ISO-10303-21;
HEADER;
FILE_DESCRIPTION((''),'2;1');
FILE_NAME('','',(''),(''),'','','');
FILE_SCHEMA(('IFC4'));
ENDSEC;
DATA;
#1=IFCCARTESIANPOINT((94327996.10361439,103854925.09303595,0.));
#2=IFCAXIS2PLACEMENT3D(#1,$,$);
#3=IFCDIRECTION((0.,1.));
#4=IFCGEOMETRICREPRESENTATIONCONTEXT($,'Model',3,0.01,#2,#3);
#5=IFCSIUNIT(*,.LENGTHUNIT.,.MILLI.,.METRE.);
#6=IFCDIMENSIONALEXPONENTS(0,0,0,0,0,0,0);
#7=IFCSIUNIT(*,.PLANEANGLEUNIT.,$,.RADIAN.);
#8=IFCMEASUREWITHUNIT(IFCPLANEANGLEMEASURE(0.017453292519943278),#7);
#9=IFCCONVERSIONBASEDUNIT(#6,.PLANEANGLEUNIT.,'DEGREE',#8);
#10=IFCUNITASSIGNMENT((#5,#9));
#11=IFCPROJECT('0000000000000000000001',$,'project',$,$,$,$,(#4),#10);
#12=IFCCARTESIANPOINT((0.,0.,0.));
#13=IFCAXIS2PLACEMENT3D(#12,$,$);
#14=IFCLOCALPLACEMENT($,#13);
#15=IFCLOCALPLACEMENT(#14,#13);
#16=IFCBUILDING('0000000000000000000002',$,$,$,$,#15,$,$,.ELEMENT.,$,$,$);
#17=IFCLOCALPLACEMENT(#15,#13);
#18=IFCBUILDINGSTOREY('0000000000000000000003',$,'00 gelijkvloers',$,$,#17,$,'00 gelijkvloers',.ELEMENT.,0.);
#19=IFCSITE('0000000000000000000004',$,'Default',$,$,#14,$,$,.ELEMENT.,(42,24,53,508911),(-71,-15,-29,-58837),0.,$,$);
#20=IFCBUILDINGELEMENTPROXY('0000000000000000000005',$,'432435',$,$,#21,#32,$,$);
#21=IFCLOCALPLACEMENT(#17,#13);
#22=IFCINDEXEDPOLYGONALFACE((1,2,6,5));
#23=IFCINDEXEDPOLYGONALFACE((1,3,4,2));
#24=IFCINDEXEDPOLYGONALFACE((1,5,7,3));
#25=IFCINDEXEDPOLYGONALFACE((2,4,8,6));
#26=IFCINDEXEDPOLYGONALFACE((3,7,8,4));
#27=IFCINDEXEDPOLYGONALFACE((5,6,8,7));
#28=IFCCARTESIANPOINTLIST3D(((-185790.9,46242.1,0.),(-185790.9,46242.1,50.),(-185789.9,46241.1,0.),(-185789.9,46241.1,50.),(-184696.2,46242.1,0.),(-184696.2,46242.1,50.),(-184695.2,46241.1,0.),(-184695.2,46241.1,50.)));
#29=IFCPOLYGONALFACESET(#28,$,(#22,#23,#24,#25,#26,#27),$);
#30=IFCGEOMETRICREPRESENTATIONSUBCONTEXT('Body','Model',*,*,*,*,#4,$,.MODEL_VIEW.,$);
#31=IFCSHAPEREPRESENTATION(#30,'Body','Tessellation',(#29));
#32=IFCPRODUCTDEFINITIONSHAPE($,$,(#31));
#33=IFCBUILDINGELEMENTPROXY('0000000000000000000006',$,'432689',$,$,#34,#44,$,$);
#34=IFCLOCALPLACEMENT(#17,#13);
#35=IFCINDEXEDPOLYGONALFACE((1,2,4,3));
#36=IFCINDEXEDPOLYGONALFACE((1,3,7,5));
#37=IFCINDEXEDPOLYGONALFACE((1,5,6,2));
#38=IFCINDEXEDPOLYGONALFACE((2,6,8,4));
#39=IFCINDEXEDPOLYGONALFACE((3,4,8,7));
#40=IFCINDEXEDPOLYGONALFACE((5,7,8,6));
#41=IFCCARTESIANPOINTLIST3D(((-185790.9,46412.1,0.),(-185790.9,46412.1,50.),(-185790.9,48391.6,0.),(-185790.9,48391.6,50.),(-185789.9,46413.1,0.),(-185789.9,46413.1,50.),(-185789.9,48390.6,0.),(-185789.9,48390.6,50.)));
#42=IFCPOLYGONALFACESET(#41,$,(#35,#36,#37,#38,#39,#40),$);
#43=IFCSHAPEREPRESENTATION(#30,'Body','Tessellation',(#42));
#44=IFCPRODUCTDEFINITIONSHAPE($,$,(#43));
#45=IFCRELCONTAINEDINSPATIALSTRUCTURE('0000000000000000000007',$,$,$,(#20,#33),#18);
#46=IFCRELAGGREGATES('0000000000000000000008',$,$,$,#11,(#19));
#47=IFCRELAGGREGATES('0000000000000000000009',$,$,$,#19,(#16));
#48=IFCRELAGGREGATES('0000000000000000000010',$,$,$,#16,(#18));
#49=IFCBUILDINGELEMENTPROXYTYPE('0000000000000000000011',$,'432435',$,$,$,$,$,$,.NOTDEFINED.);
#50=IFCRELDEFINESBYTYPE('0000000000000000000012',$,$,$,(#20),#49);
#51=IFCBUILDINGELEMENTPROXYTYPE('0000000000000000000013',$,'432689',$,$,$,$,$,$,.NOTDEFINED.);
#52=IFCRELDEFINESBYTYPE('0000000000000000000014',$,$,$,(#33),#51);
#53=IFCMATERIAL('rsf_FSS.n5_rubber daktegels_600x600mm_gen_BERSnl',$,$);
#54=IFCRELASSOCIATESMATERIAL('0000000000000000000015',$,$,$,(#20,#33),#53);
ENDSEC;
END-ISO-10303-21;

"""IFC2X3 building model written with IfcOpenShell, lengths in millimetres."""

from ifc_helpers import new_model, entity, si_unit, converted_unit, direction, frame, origin, place, context, subcontext, project, spatial, polyline, outline, extrude, material, type_object, element, save


model = new_model("IFC2X3")

# Units and contexts
model_context = context("Model", 3, precision=0.01, world=frame((94327996.10361439, 103854925.09303595, 0.0)), true_north=direction((0.0, 1.0)))
body_context = subcontext(model_context, "Body", "Model", "MODEL_VIEW")
ifc_project = project(units=[si_unit("LENGTHUNIT", "METRE", prefix="MILLI"), converted_unit("PLANEANGLEUNIT", "DEGREE", entity("IfcPlaneAngleMeasure", 0.017453292519943278), si_unit("PLANEANGLEUNIT", "RADIAN"), dimensions=[0, 0, 0, 0, 0, 0, 0])], contexts=[model_context])

# Site, building, storey
site_placement = place(None, origin())
site = spatial("IfcSite", under=ifc_project, at=site_placement, Name="Default", CompositionType="ELEMENT", RefLatitude=(42, 24, 53, 508911), RefLongitude=(-71, -15, -29, -58837), RefElevation=0.0)
building_placement = place(site_placement, origin())
building = spatial("IfcBuilding", under=site, at=building_placement, CompositionType="ELEMENT")
storey_placement = place(building_placement, origin())
storey = spatial("IfcBuildingStorey", under=building, at=storey_placement, Name="00 gelijkvloers", LongName="00 gelijkvloers", CompositionType="ELEMENT", Elevation=0.0)

# Building element proxies
ifc_material = material(Name="rsf_FSS.n5_rubber daktegels_600x600mm_gen_BERSnl")
building_element_proxy_type_1 = type_object("IfcBuildingElementProxyType", Name="432435", PredefinedType="NOTDEFINED")
proxy_1_placement = place(storey_placement, origin())
element("IfcBuildingElementProxy", 1, at=proxy_1_placement, inside=storey, type_object=building_element_proxy_type_1, material=ifc_material, Name="432435", context=body_context, shape_type="SweptSolid", body=[
    extrude(outline(polyline([(-546.8, -0.5), (547.8, -0.5), (546.8, 0.5), (-547.8, 0.5), (-546.8, -0.5)])), frame((-185243.1, 46241.6, 0.0)), (0.0, 0.0, 1.0), 50.0),
])
building_element_proxy_type_2 = type_object("IfcBuildingElementProxyType", Name="432689", PredefinedType="NOTDEFINED")
proxy_2_placement = place(storey_placement, origin())
element("IfcBuildingElementProxy", 2, at=proxy_2_placement, inside=storey, type_object=building_element_proxy_type_2, material=ifc_material, Name="432689", context=body_context, shape_type="SweptSolid", body=[
    extrude(outline(polyline([(-988.8, -0.5), (988.8, -0.5), (989.8, 0.5), (-989.8, 0.5), (-988.8, -0.5)])), frame((-185790.4, 47401.8, 0.0), z_axis=(0.0, 0.0, 1.0), x_axis=(0.0, 1.0, 0.0)), (0.0, 0.0, 1.0), 50.0),
])

save(model, "model.ifc")
